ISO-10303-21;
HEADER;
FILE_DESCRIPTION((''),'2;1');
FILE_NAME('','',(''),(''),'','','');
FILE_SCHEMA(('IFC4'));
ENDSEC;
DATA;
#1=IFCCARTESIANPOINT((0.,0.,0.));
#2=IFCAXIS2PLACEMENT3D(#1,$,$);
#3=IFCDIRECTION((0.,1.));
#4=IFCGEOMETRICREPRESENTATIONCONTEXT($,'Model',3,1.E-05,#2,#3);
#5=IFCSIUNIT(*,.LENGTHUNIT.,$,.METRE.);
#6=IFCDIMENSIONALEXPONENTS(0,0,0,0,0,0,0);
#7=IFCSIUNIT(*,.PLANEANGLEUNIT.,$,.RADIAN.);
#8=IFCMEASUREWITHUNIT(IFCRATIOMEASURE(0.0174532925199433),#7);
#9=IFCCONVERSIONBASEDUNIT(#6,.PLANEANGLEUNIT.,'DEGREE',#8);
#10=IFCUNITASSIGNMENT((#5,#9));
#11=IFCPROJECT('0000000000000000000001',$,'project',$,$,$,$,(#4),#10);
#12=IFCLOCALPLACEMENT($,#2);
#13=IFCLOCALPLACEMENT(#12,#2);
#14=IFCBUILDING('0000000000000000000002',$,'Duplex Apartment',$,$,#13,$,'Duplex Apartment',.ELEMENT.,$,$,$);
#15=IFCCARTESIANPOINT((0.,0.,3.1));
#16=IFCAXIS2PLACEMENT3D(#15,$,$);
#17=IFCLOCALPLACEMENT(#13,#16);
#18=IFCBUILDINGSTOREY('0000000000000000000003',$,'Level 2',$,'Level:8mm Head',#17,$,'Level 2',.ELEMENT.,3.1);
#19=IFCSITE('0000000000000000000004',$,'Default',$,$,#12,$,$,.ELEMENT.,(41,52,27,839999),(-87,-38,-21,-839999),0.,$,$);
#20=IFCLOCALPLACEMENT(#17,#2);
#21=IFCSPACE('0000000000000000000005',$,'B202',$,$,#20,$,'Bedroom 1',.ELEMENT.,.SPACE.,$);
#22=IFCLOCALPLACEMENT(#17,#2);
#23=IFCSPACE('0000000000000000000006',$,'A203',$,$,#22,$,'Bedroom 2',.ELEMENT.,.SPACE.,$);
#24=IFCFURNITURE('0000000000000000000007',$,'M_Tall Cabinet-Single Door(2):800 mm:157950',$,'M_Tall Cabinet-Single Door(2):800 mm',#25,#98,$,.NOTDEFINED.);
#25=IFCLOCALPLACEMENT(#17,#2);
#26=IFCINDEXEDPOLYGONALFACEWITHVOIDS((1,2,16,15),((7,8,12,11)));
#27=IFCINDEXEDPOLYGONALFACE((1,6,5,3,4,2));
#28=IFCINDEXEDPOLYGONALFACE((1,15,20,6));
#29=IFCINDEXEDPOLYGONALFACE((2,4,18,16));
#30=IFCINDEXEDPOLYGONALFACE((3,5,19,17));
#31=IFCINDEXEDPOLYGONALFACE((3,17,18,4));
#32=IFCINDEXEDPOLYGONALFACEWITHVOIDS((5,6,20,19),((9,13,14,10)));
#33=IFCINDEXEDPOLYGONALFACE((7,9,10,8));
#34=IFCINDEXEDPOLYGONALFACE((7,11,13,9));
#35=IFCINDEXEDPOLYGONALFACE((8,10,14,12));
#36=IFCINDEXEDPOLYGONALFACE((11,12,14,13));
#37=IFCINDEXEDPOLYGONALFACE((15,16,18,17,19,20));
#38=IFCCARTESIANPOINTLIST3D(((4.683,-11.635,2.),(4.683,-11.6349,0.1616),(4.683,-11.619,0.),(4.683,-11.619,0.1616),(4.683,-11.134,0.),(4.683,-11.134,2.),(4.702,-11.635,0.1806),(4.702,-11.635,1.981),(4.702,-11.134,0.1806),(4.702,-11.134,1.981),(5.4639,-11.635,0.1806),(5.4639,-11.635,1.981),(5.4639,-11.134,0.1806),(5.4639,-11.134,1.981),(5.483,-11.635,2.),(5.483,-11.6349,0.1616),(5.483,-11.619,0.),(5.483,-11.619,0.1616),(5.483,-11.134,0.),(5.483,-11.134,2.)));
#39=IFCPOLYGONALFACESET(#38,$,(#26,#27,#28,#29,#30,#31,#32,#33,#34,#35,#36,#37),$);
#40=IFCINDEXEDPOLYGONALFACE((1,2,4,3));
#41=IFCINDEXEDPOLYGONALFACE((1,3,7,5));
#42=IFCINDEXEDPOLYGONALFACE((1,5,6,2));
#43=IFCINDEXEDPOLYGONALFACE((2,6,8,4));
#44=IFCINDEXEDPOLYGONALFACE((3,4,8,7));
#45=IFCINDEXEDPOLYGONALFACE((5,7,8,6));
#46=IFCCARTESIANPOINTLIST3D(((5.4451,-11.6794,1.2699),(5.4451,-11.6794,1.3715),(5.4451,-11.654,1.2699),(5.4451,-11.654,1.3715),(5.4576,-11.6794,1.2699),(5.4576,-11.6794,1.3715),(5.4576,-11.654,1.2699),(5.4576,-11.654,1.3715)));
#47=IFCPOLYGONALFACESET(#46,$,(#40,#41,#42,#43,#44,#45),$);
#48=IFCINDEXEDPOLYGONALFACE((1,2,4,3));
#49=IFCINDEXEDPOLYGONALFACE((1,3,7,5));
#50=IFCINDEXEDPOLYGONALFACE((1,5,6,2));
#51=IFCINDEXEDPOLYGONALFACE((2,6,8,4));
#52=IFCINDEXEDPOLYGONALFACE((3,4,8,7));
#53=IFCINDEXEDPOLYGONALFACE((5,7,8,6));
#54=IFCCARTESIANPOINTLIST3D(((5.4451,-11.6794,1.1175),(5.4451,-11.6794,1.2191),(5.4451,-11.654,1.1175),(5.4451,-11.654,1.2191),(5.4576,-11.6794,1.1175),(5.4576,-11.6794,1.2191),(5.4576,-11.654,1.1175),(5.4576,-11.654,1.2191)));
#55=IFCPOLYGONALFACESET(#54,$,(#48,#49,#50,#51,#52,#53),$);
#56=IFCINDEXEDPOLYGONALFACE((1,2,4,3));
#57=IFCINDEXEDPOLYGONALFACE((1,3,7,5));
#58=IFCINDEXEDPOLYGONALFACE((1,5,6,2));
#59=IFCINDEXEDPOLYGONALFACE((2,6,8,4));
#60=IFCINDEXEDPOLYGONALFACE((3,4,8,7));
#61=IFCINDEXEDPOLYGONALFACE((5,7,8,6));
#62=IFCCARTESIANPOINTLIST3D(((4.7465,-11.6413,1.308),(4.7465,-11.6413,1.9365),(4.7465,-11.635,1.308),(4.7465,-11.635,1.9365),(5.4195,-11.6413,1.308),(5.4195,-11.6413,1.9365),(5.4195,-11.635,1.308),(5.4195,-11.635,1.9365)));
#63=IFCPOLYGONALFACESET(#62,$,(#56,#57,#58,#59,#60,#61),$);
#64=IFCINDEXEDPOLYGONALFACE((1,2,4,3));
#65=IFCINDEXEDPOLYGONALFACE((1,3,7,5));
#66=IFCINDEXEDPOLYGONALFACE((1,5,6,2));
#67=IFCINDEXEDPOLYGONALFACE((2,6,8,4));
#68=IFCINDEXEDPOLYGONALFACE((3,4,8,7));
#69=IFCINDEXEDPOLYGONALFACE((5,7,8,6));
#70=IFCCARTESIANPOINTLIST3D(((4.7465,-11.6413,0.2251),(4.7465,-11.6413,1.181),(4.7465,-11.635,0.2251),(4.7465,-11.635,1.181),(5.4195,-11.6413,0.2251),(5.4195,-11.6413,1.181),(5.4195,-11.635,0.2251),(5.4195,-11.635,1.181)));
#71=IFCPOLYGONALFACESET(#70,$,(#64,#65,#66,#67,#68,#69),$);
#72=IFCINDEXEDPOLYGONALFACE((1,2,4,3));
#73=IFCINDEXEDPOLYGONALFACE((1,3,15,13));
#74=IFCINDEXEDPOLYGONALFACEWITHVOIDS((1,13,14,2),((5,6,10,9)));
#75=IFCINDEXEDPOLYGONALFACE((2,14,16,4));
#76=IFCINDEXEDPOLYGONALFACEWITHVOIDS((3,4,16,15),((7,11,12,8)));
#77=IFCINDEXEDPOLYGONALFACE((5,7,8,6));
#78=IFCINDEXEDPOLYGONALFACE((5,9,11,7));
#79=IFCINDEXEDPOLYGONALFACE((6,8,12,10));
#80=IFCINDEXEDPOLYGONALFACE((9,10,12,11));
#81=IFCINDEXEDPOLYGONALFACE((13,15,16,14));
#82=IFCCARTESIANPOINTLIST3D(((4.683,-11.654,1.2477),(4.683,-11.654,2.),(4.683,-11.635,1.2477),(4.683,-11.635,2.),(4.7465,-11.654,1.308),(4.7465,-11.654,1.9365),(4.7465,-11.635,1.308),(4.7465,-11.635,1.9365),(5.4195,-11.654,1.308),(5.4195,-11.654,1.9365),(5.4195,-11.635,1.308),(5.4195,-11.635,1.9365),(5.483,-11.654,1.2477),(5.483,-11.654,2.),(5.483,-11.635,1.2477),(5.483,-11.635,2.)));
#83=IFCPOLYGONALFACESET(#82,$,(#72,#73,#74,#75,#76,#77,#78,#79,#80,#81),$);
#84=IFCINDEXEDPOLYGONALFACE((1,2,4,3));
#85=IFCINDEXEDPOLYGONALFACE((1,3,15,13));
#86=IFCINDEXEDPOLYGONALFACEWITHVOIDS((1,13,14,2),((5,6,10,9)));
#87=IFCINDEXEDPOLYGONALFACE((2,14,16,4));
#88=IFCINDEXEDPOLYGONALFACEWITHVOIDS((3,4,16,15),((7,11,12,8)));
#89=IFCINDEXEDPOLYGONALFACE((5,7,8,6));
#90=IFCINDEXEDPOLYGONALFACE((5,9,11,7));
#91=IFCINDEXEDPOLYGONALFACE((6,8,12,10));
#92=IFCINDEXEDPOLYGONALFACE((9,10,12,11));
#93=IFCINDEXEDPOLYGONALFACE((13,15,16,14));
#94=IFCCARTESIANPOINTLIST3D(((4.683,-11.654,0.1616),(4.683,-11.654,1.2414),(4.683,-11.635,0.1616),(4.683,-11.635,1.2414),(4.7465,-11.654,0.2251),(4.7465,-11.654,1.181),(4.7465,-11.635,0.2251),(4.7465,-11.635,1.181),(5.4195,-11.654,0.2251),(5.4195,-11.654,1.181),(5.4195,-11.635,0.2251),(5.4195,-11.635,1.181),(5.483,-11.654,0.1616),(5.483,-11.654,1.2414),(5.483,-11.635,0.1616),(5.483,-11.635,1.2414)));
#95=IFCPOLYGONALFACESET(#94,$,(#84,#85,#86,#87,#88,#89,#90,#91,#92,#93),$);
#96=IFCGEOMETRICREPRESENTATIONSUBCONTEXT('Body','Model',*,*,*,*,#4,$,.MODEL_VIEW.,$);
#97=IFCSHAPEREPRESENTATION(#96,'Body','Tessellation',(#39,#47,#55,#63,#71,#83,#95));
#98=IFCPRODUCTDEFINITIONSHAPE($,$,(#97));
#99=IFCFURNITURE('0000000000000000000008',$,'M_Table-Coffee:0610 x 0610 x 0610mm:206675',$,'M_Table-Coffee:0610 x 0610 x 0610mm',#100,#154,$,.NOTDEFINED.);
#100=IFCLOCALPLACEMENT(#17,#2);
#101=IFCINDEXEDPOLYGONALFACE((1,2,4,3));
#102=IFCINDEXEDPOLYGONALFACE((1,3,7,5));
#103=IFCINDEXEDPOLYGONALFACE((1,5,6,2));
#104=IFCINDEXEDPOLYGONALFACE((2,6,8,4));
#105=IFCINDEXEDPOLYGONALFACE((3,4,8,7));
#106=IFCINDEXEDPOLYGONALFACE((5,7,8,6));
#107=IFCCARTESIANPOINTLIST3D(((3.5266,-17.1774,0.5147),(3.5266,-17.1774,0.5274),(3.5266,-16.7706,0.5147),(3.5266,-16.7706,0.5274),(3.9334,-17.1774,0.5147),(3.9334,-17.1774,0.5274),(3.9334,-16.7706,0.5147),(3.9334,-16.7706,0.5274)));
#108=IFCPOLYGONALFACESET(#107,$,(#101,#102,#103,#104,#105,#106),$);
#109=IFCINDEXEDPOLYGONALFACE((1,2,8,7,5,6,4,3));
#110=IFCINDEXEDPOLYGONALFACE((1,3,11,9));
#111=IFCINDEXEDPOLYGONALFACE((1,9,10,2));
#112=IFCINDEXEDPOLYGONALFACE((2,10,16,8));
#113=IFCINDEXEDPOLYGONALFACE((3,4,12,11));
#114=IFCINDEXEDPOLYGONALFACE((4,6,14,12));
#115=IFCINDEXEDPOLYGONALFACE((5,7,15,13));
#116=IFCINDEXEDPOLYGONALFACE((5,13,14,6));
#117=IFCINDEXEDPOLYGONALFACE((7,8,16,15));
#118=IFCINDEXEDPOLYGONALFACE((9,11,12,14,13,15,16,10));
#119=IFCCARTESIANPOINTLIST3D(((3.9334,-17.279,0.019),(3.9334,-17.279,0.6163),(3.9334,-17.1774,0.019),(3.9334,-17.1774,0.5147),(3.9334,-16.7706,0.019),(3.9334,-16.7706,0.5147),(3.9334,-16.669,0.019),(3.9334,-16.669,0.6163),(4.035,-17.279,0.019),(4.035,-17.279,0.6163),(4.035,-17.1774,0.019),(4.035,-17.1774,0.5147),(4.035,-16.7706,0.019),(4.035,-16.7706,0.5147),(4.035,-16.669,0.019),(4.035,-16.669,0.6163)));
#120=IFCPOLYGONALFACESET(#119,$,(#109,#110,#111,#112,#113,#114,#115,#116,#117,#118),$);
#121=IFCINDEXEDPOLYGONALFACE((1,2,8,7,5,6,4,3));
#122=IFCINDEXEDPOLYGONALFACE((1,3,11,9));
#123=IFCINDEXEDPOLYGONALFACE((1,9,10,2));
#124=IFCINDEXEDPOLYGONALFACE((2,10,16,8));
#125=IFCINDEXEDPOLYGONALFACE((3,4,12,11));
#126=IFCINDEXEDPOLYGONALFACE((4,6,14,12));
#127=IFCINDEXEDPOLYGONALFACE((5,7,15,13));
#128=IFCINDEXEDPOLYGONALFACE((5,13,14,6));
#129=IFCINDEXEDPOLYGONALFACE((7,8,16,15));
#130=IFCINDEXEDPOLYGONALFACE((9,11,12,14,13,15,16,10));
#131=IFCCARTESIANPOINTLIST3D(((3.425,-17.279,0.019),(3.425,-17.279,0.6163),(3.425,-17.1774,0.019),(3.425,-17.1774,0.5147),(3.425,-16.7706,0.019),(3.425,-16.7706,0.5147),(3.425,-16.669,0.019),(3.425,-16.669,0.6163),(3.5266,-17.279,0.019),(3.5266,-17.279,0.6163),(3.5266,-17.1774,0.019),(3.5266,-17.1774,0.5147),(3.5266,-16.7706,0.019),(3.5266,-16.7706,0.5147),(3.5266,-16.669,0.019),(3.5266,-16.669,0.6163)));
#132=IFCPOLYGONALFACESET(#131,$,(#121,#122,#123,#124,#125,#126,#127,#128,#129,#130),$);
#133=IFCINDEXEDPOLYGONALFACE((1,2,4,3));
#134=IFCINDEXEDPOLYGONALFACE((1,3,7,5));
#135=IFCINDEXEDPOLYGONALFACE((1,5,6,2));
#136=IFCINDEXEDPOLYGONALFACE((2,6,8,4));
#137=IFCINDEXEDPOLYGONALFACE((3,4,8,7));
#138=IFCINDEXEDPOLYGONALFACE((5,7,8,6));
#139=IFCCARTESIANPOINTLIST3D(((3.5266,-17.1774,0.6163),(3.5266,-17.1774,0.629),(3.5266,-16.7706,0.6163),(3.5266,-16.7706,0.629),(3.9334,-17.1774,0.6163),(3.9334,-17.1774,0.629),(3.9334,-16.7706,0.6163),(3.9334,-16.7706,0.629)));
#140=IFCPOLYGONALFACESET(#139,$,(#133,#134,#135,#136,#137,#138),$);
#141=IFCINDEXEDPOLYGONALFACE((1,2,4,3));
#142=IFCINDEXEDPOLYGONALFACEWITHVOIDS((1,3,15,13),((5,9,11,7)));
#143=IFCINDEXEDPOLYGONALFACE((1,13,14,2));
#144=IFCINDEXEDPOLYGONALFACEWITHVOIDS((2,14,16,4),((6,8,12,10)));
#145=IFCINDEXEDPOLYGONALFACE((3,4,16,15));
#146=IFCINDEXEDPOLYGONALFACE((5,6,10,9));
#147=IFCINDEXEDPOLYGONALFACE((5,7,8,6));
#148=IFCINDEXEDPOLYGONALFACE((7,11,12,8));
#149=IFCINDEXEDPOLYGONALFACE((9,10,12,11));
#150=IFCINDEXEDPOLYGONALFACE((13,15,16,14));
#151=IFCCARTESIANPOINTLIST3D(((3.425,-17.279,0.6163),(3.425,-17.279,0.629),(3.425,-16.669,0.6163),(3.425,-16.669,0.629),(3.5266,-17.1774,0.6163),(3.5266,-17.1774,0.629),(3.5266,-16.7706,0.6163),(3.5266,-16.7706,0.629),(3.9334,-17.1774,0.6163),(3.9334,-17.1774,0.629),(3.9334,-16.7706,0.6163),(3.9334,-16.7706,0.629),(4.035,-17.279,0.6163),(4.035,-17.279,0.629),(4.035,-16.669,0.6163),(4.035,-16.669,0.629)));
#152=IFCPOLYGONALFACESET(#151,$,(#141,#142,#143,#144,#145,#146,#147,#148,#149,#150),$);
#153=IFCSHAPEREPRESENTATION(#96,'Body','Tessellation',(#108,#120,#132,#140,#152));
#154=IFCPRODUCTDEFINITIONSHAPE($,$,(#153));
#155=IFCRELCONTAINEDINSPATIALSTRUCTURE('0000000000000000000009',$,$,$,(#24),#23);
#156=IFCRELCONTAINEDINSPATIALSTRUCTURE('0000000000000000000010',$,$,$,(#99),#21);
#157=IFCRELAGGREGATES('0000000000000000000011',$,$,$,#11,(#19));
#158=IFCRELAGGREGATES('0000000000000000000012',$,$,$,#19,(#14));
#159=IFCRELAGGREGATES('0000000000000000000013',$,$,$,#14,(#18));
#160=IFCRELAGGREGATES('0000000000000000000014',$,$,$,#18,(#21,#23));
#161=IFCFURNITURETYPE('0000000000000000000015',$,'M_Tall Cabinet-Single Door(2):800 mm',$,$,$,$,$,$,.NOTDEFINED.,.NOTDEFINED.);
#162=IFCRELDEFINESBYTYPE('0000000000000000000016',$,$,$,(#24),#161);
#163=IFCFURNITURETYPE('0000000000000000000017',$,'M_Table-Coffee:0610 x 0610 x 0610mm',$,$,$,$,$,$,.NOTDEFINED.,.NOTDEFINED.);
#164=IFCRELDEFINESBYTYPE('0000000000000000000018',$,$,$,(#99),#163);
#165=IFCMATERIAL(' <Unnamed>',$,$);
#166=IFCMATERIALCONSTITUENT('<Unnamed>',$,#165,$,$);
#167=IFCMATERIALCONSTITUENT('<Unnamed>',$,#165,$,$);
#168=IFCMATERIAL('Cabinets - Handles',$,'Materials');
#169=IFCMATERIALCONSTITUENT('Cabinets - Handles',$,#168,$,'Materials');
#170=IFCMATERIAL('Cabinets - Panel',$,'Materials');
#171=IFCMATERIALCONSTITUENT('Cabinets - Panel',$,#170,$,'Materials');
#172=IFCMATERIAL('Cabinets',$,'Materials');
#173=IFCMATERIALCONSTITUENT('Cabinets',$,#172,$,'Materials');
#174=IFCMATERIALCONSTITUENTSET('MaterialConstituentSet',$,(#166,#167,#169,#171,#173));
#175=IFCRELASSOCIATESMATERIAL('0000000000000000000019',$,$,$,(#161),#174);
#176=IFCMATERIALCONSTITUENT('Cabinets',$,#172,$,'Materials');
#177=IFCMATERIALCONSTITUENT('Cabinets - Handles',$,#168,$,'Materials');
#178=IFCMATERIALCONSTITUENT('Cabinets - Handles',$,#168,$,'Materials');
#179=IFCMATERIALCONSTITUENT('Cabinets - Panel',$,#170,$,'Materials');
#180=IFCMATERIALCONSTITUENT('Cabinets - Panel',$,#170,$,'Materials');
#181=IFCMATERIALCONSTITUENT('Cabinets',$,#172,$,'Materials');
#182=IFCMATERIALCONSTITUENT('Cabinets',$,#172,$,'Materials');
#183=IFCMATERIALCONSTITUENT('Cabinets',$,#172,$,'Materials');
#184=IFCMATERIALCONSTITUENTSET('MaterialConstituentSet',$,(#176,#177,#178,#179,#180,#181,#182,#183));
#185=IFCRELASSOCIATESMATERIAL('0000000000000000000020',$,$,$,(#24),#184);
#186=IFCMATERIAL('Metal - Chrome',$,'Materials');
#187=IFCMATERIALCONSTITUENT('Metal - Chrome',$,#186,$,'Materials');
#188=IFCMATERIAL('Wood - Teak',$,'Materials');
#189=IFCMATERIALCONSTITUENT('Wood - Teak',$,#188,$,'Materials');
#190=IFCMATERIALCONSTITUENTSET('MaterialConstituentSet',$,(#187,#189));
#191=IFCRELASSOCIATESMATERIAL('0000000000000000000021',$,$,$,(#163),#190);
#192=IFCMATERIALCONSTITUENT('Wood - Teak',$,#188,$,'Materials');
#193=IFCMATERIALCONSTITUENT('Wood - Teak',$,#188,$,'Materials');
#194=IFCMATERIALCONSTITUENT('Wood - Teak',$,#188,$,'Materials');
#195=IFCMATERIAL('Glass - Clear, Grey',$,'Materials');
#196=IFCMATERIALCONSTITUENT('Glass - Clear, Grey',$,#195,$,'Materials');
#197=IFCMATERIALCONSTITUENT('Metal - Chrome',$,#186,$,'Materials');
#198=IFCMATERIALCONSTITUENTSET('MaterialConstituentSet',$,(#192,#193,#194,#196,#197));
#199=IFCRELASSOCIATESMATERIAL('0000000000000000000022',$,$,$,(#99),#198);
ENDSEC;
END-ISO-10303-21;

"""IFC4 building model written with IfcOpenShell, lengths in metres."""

from ifc_helpers import new_model, entity, si_unit, converted_unit, direction, frame, origin, place, context, subcontext, project, spatial, indexed_curve, outline, extrude, source, transform, mapped, material, constituent, constituent_set, type_object, type_shapes, element, save


model = new_model("IFC4")

# Units and contexts
model_context = context("Model", 3, precision=1e-05, world=origin(), true_north=direction((0.0, 1.0)))
body_context = subcontext(model_context, "Body", "Model", "MODEL_VIEW")
ifc_project = project(units=[si_unit("LENGTHUNIT", "METRE"), converted_unit("PLANEANGLEUNIT", "DEGREE", entity("IfcRatioMeasure", 0.0174532925199433), si_unit("PLANEANGLEUNIT", "RADIAN"), dimensions=[0, 0, 0, 0, 0, 0, 0])], contexts=[model_context])

# Site, building, storey
site_placement = place(None, origin())
site = spatial("IfcSite", under=ifc_project, at=site_placement, Name="Default", CompositionType="ELEMENT", RefLatitude=(41, 52, 27, 839999), RefLongitude=(-87, -38, -21, -839999), RefElevation=0.0)
building_placement = place(site_placement, origin())
building = spatial("IfcBuilding", under=site, at=building_placement, Name="Duplex Apartment", LongName="Duplex Apartment", CompositionType="ELEMENT")
storey_placement = place(building_placement, frame((0.0, 0.0, 3.1)))
storey = spatial("IfcBuildingStorey", under=building, at=storey_placement, Name="Level 2", ObjectType="Level:8mm Head", LongName="Level 2", CompositionType="ELEMENT", Elevation=3.1)

# Shared definitions
space_1_placement = place(storey_placement, origin())
space_1 = spatial("IfcSpace", under=storey, at=space_1_placement, Name="B202", LongName="Bedroom 1", CompositionType="ELEMENT", PredefinedType="SPACE")

# Shared definitions
ifc_material_1 = material(Name="Cabinets", Category="Materials")
ifc_material_2 = material(Name="Cabinets - Handles", Category="Materials")
ifc_material_3 = material(Name="Cabinets - Panel", Category="Materials")
ifc_material_4 = material(Name=" <Unnamed>")

# Shared definitions
space_2_placement = place(storey_placement, origin())
space_2 = spatial("IfcSpace", under=storey, at=space_2_placement, Name="A203", LongName="Bedroom 2", CompositionType="ELEMENT", PredefinedType="SPACE")

# Furniture, opening
ifc_constituent_1 = constituent(ifc_material_1, Name="Cabinets", Category="Materials")
ifc_constituent_2 = constituent(ifc_material_2, Name="Cabinets - Handles", Category="Materials")
ifc_constituent_3 = constituent(ifc_material_2, Name="Cabinets - Handles", Category="Materials")
ifc_constituent_4 = constituent(ifc_material_3, Name="Cabinets - Panel", Category="Materials")
ifc_constituent_5 = constituent(ifc_material_3, Name="Cabinets - Panel", Category="Materials")
ifc_constituent_6 = constituent(ifc_material_1, Name="Cabinets", Category="Materials")
ifc_constituent_7 = constituent(ifc_material_1, Name="Cabinets", Category="Materials")
ifc_constituent_8 = constituent(ifc_material_1, Name="Cabinets", Category="Materials")
ifc_constituent_set_1 = constituent_set(constituents=[ifc_constituent_1, ifc_constituent_2, ifc_constituent_3, ifc_constituent_4, ifc_constituent_5, ifc_constituent_6, ifc_constituent_7, ifc_constituent_8], Name="MaterialConstituentSet")
ifc_constituent_9 = constituent(ifc_material_4, Name="<Unnamed>")
ifc_constituent_10 = constituent(ifc_material_4, Name="<Unnamed>")
ifc_constituent_11 = constituent(ifc_material_2, Name="Cabinets - Handles", Category="Materials")
ifc_constituent_12 = constituent(ifc_material_3, Name="Cabinets - Panel", Category="Materials")
ifc_constituent_13 = constituent(ifc_material_1, Name="Cabinets", Category="Materials")
ifc_constituent_set_2 = constituent_set(constituents=[ifc_constituent_9, ifc_constituent_10, ifc_constituent_11, ifc_constituent_12, ifc_constituent_13], Name="MaterialConstituentSet")
furniture_type_1 = type_object("IfcFurnitureType", Name="M_Tall Cabinet-Single Door(2):800 mm", AssemblyPlace="NOTDEFINED", PredefinedType="NOTDEFINED", material=ifc_constituent_set_2)
shared_shape_1 = source(origin(), body_context, "Body", "SweptSolid", [
    extrude(outline(indexed_curve([(-0.1723, 0.5589), (-0.1723, -1.2795), (0.3286, -1.2795), (0.3287, 0.7205), (-0.1563, 0.7205), (-0.1563, 0.5589), (-0.1723, 0.5589)], self_intersect=False)), frame((-0.3813, -0.3286, 0.7205), z_axis=(-1.0, 0.0, 0.0), x_axis=(0.0, 1.0, 0.0)), (0.0, 0.0, -1.0), 0.8),
    extrude(outline(indexed_curve([(-0.0127, -0.0063), (0.0127, -0.0063), (0.0127, 0.0063), (-0.0127, 0.0063), (-0.0127, -0.0063)], self_intersect=False)), frame((0.3871, -0.5327, 1.2699), z_axis=(0.0, 0.0, 1.0), x_axis=(0.0, 1.0, 0.0)), (0.0, 0.0, 1.0), 0.1016),
    extrude(outline(indexed_curve([(-0.0127, -0.0063), (0.0127, -0.0063), (0.0127, 0.0063), (-0.0127, 0.0063), (-0.0127, -0.0063)], self_intersect=False)), frame((0.3871, -0.5327, 1.1175), z_axis=(0.0, 0.0, 1.0), x_axis=(0.0, 1.0, 0.0)), (0.0, 0.0, 1.0), 0.1016),
    extrude(outline(indexed_curve([(-0.0032, -0.3365), (0.0032, -0.3365), (0.0032, 0.3365), (-0.0032, 0.3365), (-0.0032, -0.3365)], self_intersect=False)), frame((0.0187, -0.5041, 1.308), z_axis=(0.0, 0.0, 1.0), x_axis=(0.0, 1.0, 0.0)), (0.0, 0.0, 1.0), 0.6285),
    extrude(outline(indexed_curve([(-0.0032, -0.3365), (0.0032, -0.3365), (0.0032, 0.3365), (-0.0032, 0.3365), (-0.0032, -0.3365)], self_intersect=False)), frame((0.0187, -0.5041, 0.2251), z_axis=(0.0, 0.0, 1.0), x_axis=(0.0, 1.0, 0.0)), (0.0, 0.0, 1.0), 0.956),
    extrude(outline(indexed_curve([(-0.3761, -0.4), (0.3761, -0.4), (0.3761, 0.4), (-0.3761, 0.4), (-0.3761, -0.4)], self_intersect=False), holes=[indexed_curve([(-0.3126, -0.3365), (-0.3126, 0.3365), (0.3158, 0.3365), (0.3158, -0.3365), (-0.3126, -0.3365)], self_intersect=False)]), frame((0.0187, -0.52, 1.6239), z_axis=(0.0, 1.0, 0.0), x_axis=(0.0, 0.0, -1.0)), (0.0, 0.0, 1.0), 0.0191),
    extrude(outline(indexed_curve([(-0.4, -0.5399), (0.4, -0.5399), (0.4, 0.5399), (-0.4, 0.5399), (-0.4, -0.5399)], self_intersect=False), holes=[indexed_curve([(-0.3365, 0.4796), (0.3365, 0.4796), (0.3365, -0.4764), (-0.3365, -0.4764), (-0.3365, 0.4796)], self_intersect=False)]), frame((0.0187, -0.52, 0.7015), z_axis=(0.0, 1.0, 0.0), x_axis=(-1.0, 0.0, 0.0)), (0.0, 0.0, 1.0), 0.0191),
    extrude(outline(indexed_curve([(-0.0095, -0.381), (0.0095, -0.381), (0.0095, 0.381), (-0.0095, 0.381), (-0.0095, -0.381)], self_intersect=False)), frame((0.0187, -0.0095, 0.1806), z_axis=(0.0, 0.0, 1.0), x_axis=(0.0, 1.0, 0.0)), (0.0, 0.0, 1.0), 1.8003),
])
type_shapes(furniture_type_1, [shared_shape_1])
furniture_1_placement = place(space_2_placement, frame((5.0643, -11.134, 0.0)))
furniture_1 = element("IfcFurniture", 1, at=furniture_1_placement, inside=space_2, type_object=furniture_type_1, material=ifc_constituent_set_1, Name="M_Tall Cabinet-Single Door(2):800 mm:157950", ObjectType="M_Tall Cabinet-Single Door(2):800 mm", PredefinedType="NOTDEFINED", context=body_context, shape_type="MappedRepresentation", body=[
    mapped(shared_shape_1, transform((0.0, 0.0, 0.0), scale=1.0)),
])
opening_1_placement = place(storey_placement, frame((5.0643, -11.134, 3.1)))
element("IfcOpeningElement", 2, at=opening_1_placement, cuts=furniture_1, ObjectType="Opening", PredefinedType="OPENING", context=body_context, shape_type="SweptSolid", body=[
    extrude(outline(indexed_curve([(-0.381, -0.9002), (0.381, -0.9002), (0.381, 0.9002), (-0.381, 0.9002), (-0.381, -0.9002)], self_intersect=False)), frame((0.0187, 0.0, -2.0192), z_axis=(0.0, -1.0, 0.0), x_axis=(-1.0, 0.0, 0.0)), (0.0, 0.0, 1.0), 0.501),
])

# Furniture
ifc_material_5 = material(Name="Wood - Teak", Category="Materials")
ifc_constituent_14 = constituent(ifc_material_5, Name="Wood - Teak", Category="Materials")
ifc_constituent_15 = constituent(ifc_material_5, Name="Wood - Teak", Category="Materials")
ifc_constituent_16 = constituent(ifc_material_5, Name="Wood - Teak", Category="Materials")
ifc_material_6 = material(Name="Glass - Clear, Grey", Category="Materials")
ifc_constituent_17 = constituent(ifc_material_6, Name="Glass - Clear, Grey", Category="Materials")
ifc_material_7 = material(Name="Metal - Chrome", Category="Materials")
ifc_constituent_18 = constituent(ifc_material_7, Name="Metal - Chrome", Category="Materials")
ifc_constituent_set_3 = constituent_set(constituents=[ifc_constituent_14, ifc_constituent_15, ifc_constituent_16, ifc_constituent_17, ifc_constituent_18], Name="MaterialConstituentSet")
ifc_constituent_19 = constituent(ifc_material_7, Name="Metal - Chrome", Category="Materials")
ifc_constituent_20 = constituent(ifc_material_5, Name="Wood - Teak", Category="Materials")
ifc_constituent_set_4 = constituent_set(constituents=[ifc_constituent_19, ifc_constituent_20], Name="MaterialConstituentSet")
furniture_type_2 = type_object("IfcFurnitureType", Name="M_Table-Coffee:0610 x 0610 x 0610mm", AssemblyPlace="NOTDEFINED", PredefinedType="NOTDEFINED", material=ifc_constituent_set_4)
shared_shape_2 = source(origin(), body_context, "Body", "SweptSolid", [
    extrude(outline(indexed_curve([(-0.2034, -0.2034), (0.2034, -0.2034), (0.2034, 0.2034), (-0.2034, 0.2034), (-0.2034, -0.2034)], self_intersect=False)), frame((0.0183, 0.0952, 0.4957), z_axis=(0.0, 0.0, 1.0), x_axis=(-1.0, 0.0, 0.0)), (0.0, 0.0, 1.0), 0.0127),
    extrude(outline(indexed_curve([(-0.2732, -0.305), (0.324, -0.305), (0.324, 0.305), (-0.2732, 0.305), (-0.2732, 0.2034), (0.2225, 0.2034), (0.2225, -0.2034), (-0.2732, -0.2034), (-0.2732, -0.305)], self_intersect=False)), frame((0.2217, 0.0952, 0.2732), z_axis=(1.0, 0.0, 0.0), x_axis=(0.0, 0.0, 1.0)), (0.0, 0.0, 1.0), 0.1016),
    extrude(outline(indexed_curve([(-0.305, -0.3241), (0.305, -0.3241), (0.305, 0.2733), (0.2034, 0.2733), (0.2034, -0.2224), (-0.2034, -0.2224), (-0.2034, 0.2733), (-0.305, 0.2733), (-0.305, -0.3241)], self_intersect=False)), frame((-0.2867, 0.0952, 0.2733), z_axis=(1.0, 0.0, 0.0), x_axis=(0.0, -1.0, 0.0)), (0.0, 0.0, 1.0), 0.1016),
    extrude(outline(indexed_curve([(-0.2034, -0.2034), (0.2034, -0.2034), (0.2034, 0.2034), (-0.2034, 0.2034), (-0.2034, -0.2034)], self_intersect=False)), frame((0.0183, 0.0952, 0.5973), z_axis=(0.0, 0.0, 1.0), x_axis=(-1.0, 0.0, 0.0)), (0.0, 0.0, 1.0), 0.0127),
    extrude(outline(indexed_curve([(-0.305, -0.305), (0.305, -0.305), (0.305, 0.305), (-0.305, 0.305), (-0.305, -0.305)], self_intersect=False), holes=[indexed_curve([(-0.2034, -0.2034), (-0.2034, 0.2034), (0.2034, 0.2034), (0.2034, -0.2034), (-0.2034, -0.2034)], self_intersect=False)]), frame((0.0183, 0.0952, 0.5973), z_axis=(0.0, 0.0, 1.0), x_axis=(-1.0, 0.0, 0.0)), (0.0, 0.0, 1.0), 0.0127),
])
type_shapes(furniture_type_2, [shared_shape_2])
furniture_2_placement = place(space_1_placement, frame((3.7117, -17.0692, 0.019)))
element("IfcFurniture", 3, at=furniture_2_placement, inside=space_1, type_object=furniture_type_2, material=ifc_constituent_set_3, Name="M_Table-Coffee:0610 x 0610 x 0610mm:206675", ObjectType="M_Table-Coffee:0610 x 0610 x 0610mm", PredefinedType="NOTDEFINED", context=body_context, shape_type="MappedRepresentation", body=[
    mapped(shared_shape_2, transform((0.0, 0.0, 0.0), scale=1.0)),
])

save(model, "model.ifc")
